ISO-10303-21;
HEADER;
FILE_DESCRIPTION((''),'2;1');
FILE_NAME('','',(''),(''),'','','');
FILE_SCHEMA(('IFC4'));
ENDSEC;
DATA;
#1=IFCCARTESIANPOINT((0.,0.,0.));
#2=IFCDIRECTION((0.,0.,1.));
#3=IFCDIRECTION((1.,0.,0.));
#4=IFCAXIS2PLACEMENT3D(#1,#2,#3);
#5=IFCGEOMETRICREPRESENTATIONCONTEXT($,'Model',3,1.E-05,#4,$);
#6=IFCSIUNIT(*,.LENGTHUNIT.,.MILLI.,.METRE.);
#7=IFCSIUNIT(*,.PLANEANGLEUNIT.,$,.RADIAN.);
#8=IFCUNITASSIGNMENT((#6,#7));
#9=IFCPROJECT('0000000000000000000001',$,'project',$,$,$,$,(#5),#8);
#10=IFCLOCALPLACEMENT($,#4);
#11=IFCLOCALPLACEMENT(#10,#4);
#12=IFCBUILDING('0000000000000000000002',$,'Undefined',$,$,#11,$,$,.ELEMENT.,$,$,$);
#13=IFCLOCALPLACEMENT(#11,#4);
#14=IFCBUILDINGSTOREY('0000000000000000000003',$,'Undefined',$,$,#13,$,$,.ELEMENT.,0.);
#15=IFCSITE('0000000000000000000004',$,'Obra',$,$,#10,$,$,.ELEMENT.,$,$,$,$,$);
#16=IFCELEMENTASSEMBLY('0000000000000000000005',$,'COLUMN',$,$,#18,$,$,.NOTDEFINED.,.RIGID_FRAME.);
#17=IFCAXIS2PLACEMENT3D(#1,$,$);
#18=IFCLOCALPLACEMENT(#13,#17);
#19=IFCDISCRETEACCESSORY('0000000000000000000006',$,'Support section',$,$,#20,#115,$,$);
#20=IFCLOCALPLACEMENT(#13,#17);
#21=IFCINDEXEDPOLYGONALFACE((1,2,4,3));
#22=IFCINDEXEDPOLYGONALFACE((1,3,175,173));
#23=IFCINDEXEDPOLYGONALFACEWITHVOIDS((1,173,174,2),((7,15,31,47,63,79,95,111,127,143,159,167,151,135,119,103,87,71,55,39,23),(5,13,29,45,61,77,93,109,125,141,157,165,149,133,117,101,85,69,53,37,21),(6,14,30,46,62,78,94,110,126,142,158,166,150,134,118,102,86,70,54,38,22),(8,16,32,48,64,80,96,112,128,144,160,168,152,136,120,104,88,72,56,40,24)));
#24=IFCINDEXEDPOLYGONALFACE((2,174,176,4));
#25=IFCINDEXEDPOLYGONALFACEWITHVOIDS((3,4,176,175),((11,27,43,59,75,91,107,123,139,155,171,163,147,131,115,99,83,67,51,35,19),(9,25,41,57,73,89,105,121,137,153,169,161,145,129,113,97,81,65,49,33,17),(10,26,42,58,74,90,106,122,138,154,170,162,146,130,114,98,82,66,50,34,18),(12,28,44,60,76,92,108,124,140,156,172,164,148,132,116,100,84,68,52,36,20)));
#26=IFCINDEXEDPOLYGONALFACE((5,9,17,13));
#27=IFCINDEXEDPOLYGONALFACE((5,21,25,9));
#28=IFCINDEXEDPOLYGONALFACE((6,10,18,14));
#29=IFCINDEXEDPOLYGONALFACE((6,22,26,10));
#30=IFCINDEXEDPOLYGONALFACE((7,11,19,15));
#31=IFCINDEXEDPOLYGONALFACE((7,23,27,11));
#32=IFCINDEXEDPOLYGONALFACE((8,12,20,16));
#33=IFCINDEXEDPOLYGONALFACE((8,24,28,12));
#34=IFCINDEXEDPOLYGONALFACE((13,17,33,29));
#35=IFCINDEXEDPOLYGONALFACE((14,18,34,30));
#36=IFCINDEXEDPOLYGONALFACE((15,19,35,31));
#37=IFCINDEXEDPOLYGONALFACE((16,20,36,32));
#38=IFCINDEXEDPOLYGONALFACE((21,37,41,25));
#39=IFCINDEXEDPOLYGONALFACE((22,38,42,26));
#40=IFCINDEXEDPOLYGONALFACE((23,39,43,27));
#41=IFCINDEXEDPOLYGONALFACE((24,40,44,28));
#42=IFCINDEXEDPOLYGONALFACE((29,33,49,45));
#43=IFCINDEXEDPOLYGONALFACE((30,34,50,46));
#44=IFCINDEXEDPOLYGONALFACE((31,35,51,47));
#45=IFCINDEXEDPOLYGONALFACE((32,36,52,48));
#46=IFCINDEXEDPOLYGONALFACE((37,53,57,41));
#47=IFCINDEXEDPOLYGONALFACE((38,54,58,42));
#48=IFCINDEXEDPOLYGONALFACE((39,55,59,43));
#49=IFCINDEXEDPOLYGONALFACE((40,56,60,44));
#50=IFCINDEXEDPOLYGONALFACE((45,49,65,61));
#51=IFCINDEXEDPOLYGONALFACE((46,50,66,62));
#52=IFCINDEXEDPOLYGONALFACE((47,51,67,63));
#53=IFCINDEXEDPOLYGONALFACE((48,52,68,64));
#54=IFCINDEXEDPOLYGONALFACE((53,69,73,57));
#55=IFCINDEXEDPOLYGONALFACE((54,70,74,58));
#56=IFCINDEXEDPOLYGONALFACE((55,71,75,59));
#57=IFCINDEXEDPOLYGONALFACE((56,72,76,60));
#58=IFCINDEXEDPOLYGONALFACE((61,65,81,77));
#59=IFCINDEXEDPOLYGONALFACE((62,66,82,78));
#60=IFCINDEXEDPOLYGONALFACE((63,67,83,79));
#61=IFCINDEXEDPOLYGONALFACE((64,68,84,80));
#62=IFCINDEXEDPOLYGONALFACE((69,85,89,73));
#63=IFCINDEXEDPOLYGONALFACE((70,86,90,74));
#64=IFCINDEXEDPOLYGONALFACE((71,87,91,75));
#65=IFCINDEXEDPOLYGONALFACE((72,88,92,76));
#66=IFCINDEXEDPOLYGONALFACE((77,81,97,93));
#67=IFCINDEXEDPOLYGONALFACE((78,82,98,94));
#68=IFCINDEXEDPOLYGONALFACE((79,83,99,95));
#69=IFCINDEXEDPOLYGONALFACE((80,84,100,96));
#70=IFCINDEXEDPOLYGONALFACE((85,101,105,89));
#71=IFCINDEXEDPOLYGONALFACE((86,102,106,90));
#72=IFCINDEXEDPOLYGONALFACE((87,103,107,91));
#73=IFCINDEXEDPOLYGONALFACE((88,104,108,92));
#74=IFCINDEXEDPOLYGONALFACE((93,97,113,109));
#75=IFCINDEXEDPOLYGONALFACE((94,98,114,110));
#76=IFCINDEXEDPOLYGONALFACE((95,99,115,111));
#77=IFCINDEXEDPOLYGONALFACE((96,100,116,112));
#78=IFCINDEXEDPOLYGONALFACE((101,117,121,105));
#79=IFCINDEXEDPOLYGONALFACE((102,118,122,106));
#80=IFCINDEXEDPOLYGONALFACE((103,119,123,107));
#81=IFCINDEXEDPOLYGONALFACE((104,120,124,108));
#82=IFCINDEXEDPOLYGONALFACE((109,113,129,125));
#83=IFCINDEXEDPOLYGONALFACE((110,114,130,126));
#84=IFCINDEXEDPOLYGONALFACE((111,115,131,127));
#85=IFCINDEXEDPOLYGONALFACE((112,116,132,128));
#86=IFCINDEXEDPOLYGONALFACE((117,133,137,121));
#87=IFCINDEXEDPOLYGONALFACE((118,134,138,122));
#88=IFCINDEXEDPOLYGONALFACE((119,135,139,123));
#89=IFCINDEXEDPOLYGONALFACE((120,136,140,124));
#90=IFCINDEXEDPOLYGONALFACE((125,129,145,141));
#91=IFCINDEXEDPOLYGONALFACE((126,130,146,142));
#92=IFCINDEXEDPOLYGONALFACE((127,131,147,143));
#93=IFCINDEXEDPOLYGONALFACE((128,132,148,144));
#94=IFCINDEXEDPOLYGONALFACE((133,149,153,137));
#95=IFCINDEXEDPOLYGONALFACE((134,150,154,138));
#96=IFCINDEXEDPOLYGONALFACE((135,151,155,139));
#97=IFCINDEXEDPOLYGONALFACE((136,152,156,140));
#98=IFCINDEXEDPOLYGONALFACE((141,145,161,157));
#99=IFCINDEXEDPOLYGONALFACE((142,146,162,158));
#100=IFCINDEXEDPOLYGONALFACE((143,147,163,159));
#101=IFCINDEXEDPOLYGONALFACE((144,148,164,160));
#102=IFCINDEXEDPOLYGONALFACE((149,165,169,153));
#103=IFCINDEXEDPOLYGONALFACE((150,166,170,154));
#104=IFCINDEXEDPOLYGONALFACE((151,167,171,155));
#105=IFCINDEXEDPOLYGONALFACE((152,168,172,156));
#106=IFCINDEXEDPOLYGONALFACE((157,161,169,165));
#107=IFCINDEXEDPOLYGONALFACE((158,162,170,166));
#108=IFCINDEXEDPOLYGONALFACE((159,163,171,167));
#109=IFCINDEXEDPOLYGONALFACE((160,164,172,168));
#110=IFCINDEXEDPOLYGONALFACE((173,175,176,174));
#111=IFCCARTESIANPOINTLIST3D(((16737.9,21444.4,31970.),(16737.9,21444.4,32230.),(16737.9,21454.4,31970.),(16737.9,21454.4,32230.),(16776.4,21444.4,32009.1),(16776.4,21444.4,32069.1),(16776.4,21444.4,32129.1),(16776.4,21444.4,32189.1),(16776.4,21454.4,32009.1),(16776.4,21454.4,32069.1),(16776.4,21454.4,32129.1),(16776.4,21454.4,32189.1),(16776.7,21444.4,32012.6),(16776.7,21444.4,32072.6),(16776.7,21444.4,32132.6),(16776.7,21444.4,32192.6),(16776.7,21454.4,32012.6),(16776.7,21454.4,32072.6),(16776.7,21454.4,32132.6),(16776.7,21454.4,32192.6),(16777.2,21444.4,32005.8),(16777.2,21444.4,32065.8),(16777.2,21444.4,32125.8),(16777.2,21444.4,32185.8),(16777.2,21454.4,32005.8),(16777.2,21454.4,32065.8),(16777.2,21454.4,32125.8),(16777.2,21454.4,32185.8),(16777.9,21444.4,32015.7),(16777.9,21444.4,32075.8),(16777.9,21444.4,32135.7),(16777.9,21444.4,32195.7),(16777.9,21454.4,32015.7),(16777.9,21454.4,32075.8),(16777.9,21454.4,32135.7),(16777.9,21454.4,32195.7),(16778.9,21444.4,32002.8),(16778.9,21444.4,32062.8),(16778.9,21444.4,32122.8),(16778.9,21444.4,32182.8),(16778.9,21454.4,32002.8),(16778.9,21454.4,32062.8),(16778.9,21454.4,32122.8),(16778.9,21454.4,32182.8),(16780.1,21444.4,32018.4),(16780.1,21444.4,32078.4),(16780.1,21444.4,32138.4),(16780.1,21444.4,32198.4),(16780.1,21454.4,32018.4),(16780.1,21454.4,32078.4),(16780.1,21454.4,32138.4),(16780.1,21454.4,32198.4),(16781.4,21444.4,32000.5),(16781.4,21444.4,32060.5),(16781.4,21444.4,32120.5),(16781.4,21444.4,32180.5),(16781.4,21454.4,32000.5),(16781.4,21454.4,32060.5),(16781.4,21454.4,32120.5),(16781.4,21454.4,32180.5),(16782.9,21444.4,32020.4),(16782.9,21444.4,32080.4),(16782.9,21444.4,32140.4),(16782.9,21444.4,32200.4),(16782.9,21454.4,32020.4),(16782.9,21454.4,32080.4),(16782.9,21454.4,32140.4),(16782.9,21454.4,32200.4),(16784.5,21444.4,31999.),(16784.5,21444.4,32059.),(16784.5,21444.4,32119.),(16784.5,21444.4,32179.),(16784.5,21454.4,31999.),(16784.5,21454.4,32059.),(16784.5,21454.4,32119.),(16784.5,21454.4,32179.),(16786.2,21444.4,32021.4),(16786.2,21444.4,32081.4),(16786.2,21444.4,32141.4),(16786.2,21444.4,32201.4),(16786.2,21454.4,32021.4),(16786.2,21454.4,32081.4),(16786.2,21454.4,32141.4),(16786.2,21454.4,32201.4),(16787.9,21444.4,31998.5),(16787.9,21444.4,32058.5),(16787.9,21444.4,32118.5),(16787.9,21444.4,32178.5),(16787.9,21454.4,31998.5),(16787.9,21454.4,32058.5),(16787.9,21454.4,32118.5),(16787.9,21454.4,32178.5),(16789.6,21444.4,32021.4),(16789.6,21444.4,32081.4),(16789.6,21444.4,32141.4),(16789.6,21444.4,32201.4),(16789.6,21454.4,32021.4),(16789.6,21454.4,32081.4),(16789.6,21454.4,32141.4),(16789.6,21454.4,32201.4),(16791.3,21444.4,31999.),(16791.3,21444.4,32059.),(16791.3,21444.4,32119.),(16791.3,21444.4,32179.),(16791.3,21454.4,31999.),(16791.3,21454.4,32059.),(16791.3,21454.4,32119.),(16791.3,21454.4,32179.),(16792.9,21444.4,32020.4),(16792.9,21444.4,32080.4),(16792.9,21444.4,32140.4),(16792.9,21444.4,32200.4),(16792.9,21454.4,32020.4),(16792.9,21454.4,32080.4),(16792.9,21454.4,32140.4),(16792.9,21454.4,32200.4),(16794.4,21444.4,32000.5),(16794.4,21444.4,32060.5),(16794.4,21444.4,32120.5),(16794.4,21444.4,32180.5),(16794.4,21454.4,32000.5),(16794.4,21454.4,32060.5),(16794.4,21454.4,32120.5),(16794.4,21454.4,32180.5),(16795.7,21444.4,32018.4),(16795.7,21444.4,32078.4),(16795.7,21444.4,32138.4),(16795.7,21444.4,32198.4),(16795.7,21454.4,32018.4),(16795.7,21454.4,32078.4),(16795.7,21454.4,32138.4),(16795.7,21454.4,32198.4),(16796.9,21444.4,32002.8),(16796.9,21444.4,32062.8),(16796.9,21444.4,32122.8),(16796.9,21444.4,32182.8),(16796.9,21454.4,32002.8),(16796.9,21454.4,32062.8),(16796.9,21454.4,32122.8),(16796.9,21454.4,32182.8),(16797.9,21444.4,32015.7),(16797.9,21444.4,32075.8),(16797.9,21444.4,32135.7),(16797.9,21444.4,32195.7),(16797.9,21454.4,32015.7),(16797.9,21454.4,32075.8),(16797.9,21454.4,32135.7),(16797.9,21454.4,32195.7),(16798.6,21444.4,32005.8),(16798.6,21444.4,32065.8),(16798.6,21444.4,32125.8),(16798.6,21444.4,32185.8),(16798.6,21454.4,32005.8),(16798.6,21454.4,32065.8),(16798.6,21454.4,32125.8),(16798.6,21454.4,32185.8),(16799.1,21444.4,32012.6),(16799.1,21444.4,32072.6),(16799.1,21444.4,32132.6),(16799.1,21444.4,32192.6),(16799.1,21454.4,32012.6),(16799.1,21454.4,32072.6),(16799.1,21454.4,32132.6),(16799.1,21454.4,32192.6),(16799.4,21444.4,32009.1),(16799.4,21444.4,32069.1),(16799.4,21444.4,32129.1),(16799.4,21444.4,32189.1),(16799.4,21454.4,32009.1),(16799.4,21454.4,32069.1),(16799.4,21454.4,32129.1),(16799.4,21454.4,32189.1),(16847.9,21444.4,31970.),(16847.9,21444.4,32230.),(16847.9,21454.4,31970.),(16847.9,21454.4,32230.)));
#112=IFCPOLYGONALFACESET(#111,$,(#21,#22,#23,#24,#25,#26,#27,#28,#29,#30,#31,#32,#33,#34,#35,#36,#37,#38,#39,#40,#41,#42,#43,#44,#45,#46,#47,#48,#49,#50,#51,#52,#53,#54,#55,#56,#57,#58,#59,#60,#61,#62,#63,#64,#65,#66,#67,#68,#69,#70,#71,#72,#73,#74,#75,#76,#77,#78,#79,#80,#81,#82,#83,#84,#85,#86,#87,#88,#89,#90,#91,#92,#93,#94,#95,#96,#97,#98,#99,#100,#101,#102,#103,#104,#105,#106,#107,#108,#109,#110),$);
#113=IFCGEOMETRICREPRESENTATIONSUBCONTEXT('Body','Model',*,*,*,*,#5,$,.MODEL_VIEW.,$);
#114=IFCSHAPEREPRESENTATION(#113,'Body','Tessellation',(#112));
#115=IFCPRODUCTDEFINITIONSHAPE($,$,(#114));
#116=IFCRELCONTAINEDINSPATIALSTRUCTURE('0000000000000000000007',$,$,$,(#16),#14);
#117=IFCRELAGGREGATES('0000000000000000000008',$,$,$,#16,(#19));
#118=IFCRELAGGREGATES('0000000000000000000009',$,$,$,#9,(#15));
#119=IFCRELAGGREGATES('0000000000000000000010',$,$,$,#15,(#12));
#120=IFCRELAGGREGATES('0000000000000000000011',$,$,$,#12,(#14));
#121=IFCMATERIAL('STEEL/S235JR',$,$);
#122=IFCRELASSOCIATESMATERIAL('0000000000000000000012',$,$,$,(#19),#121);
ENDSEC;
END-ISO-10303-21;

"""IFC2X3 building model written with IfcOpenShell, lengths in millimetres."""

from ifc_helpers import new_model, si_unit, frame, origin_with_axes, origin_2d_with_axis, place, context, subcontext, project, spatial, rectangle, circle, extrude, source, transform, mapped, material, element, aggregate, save


model = new_model("IFC2X3")

# Units and contexts
model_context = context("Model", 3, precision=1e-05, world=origin_with_axes())
body_context = subcontext(model_context, "Body", "Model", "MODEL_VIEW")
ifc_project = project(units=[si_unit("LENGTHUNIT", "METRE", prefix="MILLI"), si_unit("PLANEANGLEUNIT", "RADIAN")], contexts=[model_context])

# Site, building, storey
site_placement = place(None, origin_with_axes())
site = spatial("IfcSite", under=ifc_project, at=site_placement, Name="Obra", CompositionType="ELEMENT")
building_placement = place(site_placement, origin_with_axes())
building = spatial("IfcBuilding", under=site, at=building_placement, Name="Undefined", CompositionType="ELEMENT")
storey_placement = place(building_placement, origin_with_axes())
storey = spatial("IfcBuildingStorey", under=building, at=storey_placement, Name="Undefined", CompositionType="ELEMENT", Elevation=0.0)

# Element assembly
assembly_1_placement = place(storey_placement, origin_with_axes())
assembly_1 = element("IfcElementAssembly", 1, at=assembly_1_placement, inside=storey, Name="COLUMN", AssemblyPlace="NOTDEFINED", PredefinedType="RIGID_FRAME")
ifc_material_1 = material(Name="STEEL/S235JR")

# Shared definitions
shared_shape_1 = source(origin_with_axes(), body_context, "Body", "SweptSolid", [
    extrude(circle(Radius=11.5, at=origin_2d_with_axis()), frame((0.0, -14.4, 0.0), z_axis=(0.0, 1.0, 0.0), x_axis=(1.0, 0.0, 0.0)), (0.0, 0.0, 1.0), 10.2),
])

# Discrete accessory, opening
discrete_accessory_1_placement = place(assembly_1_placement, frame((16792.9, 21449.4, 31970.0), z_axis=(0.0, 0.0, 1.0), x_axis=(1.0, 0.0, 0.0)))
discrete_accessory_1 = element("IfcDiscreteAccessory", 2, at=discrete_accessory_1_placement, material=ifc_material_1, Name="Support section", context=body_context, shape_type="SweptSolid", body=[
    extrude(rectangle(XDim=10.0, YDim=110.0, at=origin_2d_with_axis()), frame((0.0, 0.0, 260.0), z_axis=(0.0, 0.0, -1.0), x_axis=(0.0, 1.0, 0.0)), (0.0, 0.0, 1.0), 260.0),
])
opening_1_placement = place(assembly_1_placement, frame((16837.9, 21440.1, 32300.0), z_axis=(-1.0, 0.0, 0.0), x_axis=(0.0, 0.0, -1.0)))
element("IfcOpeningElement", 3, at=opening_1_placement, cuts=discrete_accessory_1, ObjectType="Opening", context=body_context, shape_type="MappedRepresentation", body=[
    mapped(shared_shape_1, transform((110.0, 0.0, 50.0))),
    mapped(shared_shape_1, transform((170.0, 0.0, 50.0))),
    mapped(shared_shape_1, transform((230.0, 0.0, 50.0))),
    mapped(shared_shape_1, transform((290.0, 0.0, 50.0))),
])
aggregate(assembly_1, [discrete_accessory_1])

save(model, "model.ifc")
